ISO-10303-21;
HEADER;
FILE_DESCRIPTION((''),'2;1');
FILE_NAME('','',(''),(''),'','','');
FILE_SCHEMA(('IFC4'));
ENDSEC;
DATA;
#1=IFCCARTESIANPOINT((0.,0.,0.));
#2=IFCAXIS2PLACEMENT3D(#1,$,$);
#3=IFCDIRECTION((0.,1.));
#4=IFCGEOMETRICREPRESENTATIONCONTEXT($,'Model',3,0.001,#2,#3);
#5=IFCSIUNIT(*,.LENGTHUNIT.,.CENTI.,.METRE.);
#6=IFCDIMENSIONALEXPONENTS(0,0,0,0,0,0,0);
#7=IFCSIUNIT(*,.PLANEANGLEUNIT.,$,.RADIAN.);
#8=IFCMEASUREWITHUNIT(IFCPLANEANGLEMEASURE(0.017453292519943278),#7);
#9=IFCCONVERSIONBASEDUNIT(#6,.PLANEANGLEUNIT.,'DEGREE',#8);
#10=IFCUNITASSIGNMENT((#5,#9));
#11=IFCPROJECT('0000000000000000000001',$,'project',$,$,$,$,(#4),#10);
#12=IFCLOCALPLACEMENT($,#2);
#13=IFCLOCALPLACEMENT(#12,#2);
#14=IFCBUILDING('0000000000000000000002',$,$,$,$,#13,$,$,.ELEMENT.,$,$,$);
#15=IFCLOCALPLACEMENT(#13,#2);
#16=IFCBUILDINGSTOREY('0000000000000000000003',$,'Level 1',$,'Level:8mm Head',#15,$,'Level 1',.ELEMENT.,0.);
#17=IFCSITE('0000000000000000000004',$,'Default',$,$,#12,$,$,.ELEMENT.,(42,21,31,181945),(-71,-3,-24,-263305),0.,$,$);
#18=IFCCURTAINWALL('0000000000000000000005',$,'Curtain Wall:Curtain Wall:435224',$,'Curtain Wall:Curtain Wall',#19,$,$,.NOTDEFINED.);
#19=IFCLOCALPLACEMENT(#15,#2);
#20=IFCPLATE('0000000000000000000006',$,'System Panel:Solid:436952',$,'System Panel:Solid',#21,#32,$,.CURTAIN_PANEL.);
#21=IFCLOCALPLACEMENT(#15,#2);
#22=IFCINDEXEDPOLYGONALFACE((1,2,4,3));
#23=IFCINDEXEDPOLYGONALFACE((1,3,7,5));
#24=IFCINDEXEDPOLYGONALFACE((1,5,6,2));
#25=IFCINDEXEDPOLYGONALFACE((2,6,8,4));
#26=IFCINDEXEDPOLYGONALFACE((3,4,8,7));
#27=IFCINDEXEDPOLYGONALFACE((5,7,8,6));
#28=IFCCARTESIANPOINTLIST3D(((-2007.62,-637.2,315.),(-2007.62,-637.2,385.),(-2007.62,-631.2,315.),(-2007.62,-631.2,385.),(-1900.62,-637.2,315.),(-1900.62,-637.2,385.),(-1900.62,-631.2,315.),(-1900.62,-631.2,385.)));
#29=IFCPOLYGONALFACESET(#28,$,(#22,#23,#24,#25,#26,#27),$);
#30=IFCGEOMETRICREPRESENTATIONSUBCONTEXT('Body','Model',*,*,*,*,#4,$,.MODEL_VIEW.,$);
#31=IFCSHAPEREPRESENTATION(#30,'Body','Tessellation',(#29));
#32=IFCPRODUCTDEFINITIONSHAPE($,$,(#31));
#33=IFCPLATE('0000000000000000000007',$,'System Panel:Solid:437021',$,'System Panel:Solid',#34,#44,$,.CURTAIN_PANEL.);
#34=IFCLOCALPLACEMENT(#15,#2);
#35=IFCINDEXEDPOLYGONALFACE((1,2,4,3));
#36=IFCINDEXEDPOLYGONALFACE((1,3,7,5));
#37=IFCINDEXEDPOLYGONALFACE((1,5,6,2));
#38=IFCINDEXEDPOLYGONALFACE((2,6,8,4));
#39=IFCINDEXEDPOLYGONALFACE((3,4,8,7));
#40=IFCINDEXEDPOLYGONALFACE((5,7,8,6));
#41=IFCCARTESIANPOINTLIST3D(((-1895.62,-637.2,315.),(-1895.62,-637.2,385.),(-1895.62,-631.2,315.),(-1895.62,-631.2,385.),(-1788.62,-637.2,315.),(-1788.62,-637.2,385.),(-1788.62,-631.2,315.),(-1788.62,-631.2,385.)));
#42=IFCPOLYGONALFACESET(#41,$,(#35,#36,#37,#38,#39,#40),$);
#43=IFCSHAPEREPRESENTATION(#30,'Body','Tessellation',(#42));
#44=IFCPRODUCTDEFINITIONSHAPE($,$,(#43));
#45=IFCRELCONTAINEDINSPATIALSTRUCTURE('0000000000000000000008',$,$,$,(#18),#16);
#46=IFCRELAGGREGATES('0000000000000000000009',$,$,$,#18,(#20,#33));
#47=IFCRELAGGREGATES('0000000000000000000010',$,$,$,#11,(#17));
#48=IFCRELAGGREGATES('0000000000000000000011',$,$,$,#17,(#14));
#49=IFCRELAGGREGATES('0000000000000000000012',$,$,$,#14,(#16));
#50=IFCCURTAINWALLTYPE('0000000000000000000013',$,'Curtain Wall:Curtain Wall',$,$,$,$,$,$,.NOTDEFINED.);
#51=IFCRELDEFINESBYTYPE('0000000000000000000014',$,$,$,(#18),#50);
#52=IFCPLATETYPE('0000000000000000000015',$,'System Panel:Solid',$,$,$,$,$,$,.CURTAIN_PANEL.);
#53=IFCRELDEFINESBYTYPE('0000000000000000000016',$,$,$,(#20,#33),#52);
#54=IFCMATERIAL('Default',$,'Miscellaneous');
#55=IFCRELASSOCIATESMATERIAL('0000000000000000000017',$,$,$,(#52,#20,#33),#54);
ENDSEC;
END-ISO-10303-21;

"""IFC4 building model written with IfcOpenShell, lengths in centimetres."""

from ifc_helpers import new_model, entity, si_unit, converted_unit, direction, frame, origin, place, context, subcontext, project, spatial, indexed_curve, outline, extrude, source, transform, mapped, material, type_object, type_shapes, element, aggregate, save


model = new_model("IFC4")

# Units and contexts
model_context = context("Model", 3, precision=0.001, world=origin(), true_north=direction((0.0, 1.0)))
body_context = subcontext(model_context, "Body", "Model", "MODEL_VIEW")
ifc_project = project(units=[si_unit("LENGTHUNIT", "METRE", prefix="CENTI"), converted_unit("PLANEANGLEUNIT", "DEGREE", entity("IfcPlaneAngleMeasure", 0.017453292519943278), si_unit("PLANEANGLEUNIT", "RADIAN"), dimensions=[0, 0, 0, 0, 0, 0, 0])], contexts=[model_context])

# Site, building, storey
site_placement = place(None, origin())
site = spatial("IfcSite", under=ifc_project, at=site_placement, Name="Default", CompositionType="ELEMENT", RefLatitude=(42, 21, 31, 181945), RefLongitude=(-71, -3, -24, -263305), RefElevation=0.0)
building_placement = place(site_placement, origin())
building = spatial("IfcBuilding", under=site, at=building_placement, CompositionType="ELEMENT")
storey_placement = place(building_placement, origin())
storey = spatial("IfcBuildingStorey", under=building, at=storey_placement, Name="Level 1", ObjectType="Level:8mm Head", LongName="Level 1", CompositionType="ELEMENT", Elevation=0.0)

# Curtain wall, plates
curtain_wall_type = type_object("IfcCurtainWallType", Name="Curtain Wall:Curtain Wall", PredefinedType="NOTDEFINED")
curtain_wall_placement = place(storey_placement, origin())
curtain_wall = element("IfcCurtainWall", 1, at=curtain_wall_placement, inside=storey, type_object=curtain_wall_type, Name="Curtain Wall:Curtain Wall:435224", ObjectType="Curtain Wall:Curtain Wall", PredefinedType="NOTDEFINED")
ifc_material_1 = material(Name="Default", Category="Miscellaneous")
plate_type_1 = type_object("IfcPlateType", Name="System Panel:Solid", PredefinedType="CURTAIN_PANEL", material=ifc_material_1)
shared_shape_1 = source(origin(), body_context, "Body", "SweptSolid", [
    extrude(outline(indexed_curve([(-3.0, -53.5), (3.0, -53.5), (3.0, 53.5), (-3.0, 53.5), (-3.0, -53.5)], self_intersect=False)), frame((0.0, 1.95, 0.0), z_axis=(0.0, 0.0, 1.0), x_axis=(0.0, 1.0, 0.0)), (0.0, 0.0, 1.0), 70.0),
])
type_shapes(plate_type_1, [shared_shape_1])
plate_1_placement = place(curtain_wall_placement, frame((-1954.12, -636.15, 315.0)))
plate_1 = element("IfcPlate", 2, at=plate_1_placement, type_object=plate_type_1, material=ifc_material_1, Name="System Panel:Solid:436952", ObjectType="System Panel:Solid", PredefinedType="CURTAIN_PANEL", context=body_context, shape_type="MappedRepresentation", body=[
    mapped(shared_shape_1, transform((0.0, 0.0, 0.0), scale=1.0)),
])
plate_2_placement = place(curtain_wall_placement, frame((-1842.12, -636.15, 315.0)))
plate_2 = element("IfcPlate", 3, at=plate_2_placement, type_object=plate_type_1, material=ifc_material_1, Name="System Panel:Solid:437021", ObjectType="System Panel:Solid", PredefinedType="CURTAIN_PANEL", context=body_context, shape_type="MappedRepresentation", body=[
    mapped(shared_shape_1, transform((0.0, 0.0, 0.0), scale=1.0)),
])
aggregate(curtain_wall, [plate_1, plate_2])

save(model, "model.ifc")
